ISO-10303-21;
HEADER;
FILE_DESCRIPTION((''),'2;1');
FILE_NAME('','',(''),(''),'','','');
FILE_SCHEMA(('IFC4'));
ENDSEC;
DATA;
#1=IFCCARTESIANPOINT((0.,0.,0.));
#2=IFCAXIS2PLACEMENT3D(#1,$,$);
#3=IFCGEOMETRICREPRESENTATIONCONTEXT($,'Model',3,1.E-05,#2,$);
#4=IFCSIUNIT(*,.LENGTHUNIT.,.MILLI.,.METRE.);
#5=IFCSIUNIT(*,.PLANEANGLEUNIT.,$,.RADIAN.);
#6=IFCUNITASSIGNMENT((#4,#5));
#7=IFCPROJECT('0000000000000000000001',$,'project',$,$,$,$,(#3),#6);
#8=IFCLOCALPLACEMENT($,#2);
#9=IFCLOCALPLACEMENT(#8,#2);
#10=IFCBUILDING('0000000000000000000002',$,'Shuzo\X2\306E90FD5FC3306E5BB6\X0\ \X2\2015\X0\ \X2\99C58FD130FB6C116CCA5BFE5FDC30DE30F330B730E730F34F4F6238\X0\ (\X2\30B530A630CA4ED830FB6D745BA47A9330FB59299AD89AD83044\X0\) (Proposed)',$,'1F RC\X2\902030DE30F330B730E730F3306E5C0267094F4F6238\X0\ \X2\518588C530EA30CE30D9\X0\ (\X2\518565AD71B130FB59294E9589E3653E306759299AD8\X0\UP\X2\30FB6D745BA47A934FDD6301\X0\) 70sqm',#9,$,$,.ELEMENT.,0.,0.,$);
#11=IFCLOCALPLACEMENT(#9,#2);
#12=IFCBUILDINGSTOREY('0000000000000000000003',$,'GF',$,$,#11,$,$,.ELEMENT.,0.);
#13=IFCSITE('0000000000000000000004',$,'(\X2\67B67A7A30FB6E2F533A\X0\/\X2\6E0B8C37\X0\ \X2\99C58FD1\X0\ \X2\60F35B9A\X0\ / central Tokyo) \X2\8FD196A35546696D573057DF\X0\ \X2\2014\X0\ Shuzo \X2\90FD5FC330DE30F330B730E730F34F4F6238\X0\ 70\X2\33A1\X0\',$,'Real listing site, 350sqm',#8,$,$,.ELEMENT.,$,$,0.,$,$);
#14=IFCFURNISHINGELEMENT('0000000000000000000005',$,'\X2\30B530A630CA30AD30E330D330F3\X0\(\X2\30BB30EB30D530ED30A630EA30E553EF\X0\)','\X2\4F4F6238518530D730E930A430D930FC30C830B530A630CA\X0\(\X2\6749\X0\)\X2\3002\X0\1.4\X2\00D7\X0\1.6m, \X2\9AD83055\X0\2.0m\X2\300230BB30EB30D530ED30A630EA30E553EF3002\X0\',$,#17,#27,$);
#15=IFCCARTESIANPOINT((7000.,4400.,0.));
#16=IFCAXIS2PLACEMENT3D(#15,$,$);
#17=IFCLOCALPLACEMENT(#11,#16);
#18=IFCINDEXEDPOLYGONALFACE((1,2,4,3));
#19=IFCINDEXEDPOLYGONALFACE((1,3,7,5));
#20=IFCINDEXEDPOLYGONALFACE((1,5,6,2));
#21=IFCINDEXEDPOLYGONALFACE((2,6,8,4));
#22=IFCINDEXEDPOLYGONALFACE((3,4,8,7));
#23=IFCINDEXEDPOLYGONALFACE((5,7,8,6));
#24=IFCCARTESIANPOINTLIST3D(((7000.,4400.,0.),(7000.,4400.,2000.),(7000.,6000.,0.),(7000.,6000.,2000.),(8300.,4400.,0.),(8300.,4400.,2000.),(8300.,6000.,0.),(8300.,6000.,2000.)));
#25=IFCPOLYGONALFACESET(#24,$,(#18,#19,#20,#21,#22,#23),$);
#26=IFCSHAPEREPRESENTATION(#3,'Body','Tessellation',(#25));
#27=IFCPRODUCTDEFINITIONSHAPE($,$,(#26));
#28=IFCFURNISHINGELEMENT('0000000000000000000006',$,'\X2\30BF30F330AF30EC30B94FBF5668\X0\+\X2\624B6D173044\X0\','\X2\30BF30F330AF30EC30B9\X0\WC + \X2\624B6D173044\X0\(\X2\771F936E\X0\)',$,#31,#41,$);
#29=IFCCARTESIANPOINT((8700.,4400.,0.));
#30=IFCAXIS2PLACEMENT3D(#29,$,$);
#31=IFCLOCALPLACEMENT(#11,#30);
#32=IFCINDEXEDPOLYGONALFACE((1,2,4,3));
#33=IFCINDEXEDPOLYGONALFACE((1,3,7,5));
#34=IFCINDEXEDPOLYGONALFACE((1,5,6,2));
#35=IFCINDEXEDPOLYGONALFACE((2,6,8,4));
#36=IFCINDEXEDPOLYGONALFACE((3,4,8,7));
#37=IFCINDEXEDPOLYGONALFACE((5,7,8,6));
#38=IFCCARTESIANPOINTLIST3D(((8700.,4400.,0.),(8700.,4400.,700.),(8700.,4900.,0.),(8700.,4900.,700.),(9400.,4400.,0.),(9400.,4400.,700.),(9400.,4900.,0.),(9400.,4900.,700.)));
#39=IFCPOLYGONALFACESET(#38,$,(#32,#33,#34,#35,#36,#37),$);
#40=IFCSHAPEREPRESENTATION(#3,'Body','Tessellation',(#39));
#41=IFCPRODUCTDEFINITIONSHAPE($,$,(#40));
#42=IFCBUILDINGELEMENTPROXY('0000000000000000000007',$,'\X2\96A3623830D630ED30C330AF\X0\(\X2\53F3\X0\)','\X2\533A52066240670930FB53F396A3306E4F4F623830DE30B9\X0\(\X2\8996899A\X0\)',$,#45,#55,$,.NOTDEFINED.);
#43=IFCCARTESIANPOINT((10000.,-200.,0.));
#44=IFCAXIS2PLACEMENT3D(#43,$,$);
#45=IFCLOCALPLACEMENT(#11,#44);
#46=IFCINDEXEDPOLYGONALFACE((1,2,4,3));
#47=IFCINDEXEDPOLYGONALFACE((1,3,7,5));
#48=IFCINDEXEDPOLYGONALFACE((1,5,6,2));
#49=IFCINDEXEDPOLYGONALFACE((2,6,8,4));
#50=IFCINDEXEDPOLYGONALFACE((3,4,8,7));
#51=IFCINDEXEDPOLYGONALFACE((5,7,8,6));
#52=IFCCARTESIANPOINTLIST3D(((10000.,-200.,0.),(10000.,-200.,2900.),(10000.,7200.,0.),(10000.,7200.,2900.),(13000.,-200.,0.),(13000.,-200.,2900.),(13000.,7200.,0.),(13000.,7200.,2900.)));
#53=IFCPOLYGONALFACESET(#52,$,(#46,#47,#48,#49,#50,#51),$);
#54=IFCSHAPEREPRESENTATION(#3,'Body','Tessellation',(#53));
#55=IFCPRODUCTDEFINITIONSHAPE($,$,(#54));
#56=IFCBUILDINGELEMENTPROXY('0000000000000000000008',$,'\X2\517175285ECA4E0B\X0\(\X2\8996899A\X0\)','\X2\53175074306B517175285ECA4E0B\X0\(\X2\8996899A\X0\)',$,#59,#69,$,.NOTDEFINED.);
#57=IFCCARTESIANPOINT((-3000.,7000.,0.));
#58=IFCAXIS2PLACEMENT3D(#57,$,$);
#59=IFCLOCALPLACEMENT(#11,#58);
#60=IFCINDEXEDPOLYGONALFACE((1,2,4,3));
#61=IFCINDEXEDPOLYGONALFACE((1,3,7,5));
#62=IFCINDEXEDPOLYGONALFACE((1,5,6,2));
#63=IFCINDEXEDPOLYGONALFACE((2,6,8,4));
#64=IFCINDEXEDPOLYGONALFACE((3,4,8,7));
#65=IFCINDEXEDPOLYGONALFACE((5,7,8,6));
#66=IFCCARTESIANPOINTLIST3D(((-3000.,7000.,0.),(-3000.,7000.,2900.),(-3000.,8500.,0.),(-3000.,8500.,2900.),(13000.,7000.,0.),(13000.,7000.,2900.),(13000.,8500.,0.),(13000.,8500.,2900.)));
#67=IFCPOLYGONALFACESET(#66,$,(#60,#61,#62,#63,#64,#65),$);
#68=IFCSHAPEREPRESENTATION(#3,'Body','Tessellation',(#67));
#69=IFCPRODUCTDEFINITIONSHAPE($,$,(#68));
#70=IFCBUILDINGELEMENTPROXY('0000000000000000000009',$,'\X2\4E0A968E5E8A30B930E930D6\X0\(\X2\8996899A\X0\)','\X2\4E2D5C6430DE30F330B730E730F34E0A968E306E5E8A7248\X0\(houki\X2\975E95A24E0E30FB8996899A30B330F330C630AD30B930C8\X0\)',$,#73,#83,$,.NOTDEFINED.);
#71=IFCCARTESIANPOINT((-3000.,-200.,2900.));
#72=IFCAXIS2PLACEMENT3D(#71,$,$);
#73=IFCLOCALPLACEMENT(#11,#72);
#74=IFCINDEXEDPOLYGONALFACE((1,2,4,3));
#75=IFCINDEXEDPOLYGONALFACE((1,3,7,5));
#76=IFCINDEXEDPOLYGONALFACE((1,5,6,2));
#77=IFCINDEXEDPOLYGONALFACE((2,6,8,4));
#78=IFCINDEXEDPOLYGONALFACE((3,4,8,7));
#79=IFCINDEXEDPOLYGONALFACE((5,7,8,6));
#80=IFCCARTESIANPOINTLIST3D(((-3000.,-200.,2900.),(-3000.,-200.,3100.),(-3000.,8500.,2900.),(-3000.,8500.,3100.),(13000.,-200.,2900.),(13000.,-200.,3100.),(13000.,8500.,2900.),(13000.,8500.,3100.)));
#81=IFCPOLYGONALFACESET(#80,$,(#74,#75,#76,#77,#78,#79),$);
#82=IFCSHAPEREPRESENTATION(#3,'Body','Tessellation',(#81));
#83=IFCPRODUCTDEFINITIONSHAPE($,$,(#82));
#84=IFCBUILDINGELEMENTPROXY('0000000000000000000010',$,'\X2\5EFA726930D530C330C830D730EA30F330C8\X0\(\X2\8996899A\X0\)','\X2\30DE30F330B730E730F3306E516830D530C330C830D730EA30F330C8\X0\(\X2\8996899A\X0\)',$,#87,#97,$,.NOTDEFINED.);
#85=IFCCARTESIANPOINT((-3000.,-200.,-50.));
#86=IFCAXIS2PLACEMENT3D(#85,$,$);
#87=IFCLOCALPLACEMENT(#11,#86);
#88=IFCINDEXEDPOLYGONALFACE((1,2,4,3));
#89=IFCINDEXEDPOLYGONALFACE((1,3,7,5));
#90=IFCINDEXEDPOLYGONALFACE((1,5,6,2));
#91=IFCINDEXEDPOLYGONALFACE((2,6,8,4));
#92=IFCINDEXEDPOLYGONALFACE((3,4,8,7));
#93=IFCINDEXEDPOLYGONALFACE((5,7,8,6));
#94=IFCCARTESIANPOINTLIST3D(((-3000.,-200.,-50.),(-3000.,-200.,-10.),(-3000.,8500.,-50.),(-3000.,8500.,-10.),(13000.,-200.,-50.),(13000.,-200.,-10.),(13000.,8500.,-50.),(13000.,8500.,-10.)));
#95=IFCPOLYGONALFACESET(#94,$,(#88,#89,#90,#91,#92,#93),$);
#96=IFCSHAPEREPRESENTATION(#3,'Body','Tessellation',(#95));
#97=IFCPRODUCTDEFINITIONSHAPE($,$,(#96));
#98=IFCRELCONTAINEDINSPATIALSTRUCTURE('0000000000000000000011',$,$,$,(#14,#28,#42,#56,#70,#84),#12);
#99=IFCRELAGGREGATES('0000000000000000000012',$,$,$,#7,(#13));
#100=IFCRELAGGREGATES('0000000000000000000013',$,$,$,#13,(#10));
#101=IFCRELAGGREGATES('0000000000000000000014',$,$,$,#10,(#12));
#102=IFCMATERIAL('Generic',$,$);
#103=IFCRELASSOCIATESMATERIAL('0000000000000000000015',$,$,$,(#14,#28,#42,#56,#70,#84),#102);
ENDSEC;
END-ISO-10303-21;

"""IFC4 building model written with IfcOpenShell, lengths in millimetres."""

from ifc_helpers import new_model, si_unit, frame, frame_2d, origin, place, context, project, spatial, rectangle, extrude, material, element, save


model = new_model("IFC4")

# Units and contexts
model_context = context("Model", 3, precision=1e-05, world=origin())
ifc_project = project(units=[si_unit("LENGTHUNIT", "METRE", prefix="MILLI"), si_unit("PLANEANGLEUNIT", "RADIAN")], contexts=[model_context])

# Site, building, storey
site_placement = place(None, origin())
site = spatial("IfcSite", under=ifc_project, at=site_placement, Name="(架空・港区/渋谷 駅近 想定 / central Tokyo) 近隣商業地域 — Shuzo 都心マンション住戸 70㎡", ObjectType="Real listing site, 350sqm", CompositionType="ELEMENT", RefElevation=0.0)
building_placement = place(site_placement, origin())
building = spatial("IfcBuilding", under=site, at=building_placement, Name="Shuzoの都心の家 ― 駅近・民泊対応マンション住戸 (サウナ付・浴室窓・天高高い) (Proposed)", ObjectType="1F RC造マンションの専有住戸 内装リノベ (内断熱・天井解放で天高UP・浴室窓保持) 70sqm", CompositionType="ELEMENT", ElevationOfRefHeight=0.0, ElevationOfTerrain=0.0)
storey_placement = place(building_placement, origin())
storey = spatial("IfcBuildingStorey", under=building, at=storey_placement, Name="GF", CompositionType="ELEMENT", Elevation=0.0)

# Shared definitions
ifc_material = material(Name="Generic")

# Furnishing elements
furnishing_1_placement = place(storey_placement, frame((7000.0, 4400.0, 0.0)))
element("IfcFurnishingElement", 1, at=furnishing_1_placement, inside=storey, material=ifc_material, Name="サウナキャビン(セルフロウリュ可)", Description="住戸内プライベートサウナ(杉)。1.4×1.6m, 高さ2.0m。セルフロウリュ可。", context=model_context, shape_type="SweptSolid", body=[
    extrude(rectangle(XDim=1300.0, YDim=1600.0, at=frame_2d((650.0, 800.0))), frame((7000.0, 4400.0, 0.0)), (0.0, 0.0, 1.0), 2000.0),
])
furnishing_2_placement = place(storey_placement, frame((8700.0, 4400.0, 0.0)))
element("IfcFurnishingElement", 2, at=furnishing_2_placement, inside=storey, material=ifc_material, Name="タンクレス便器+手洗い", Description="タンクレスWC + 手洗い(真鍮)", context=model_context, shape_type="SweptSolid", body=[
    extrude(rectangle(XDim=700.0, YDim=500.0, at=frame_2d((350.0, 250.0))), frame((8700.0, 4400.0, 0.0)), (0.0, 0.0, 1.0), 700.0),
])

# Building element proxies
proxy_1_placement = place(storey_placement, frame((10000.0, -200.0, 0.0)))
element("IfcBuildingElementProxy", 3, at=proxy_1_placement, inside=storey, material=ifc_material, Name="隣戸ブロック(右)", Description="区分所有・右隣の住戸マス(視覚)", PredefinedType="NOTDEFINED", context=model_context, shape_type="SweptSolid", body=[
    extrude(rectangle(XDim=3000.0, YDim=7400.0, at=frame_2d((1500.0, 3700.0))), frame((10000.0, -200.0, 0.0)), (0.0, 0.0, 1.0), 2900.0),
])
proxy_2_placement = place(storey_placement, frame((-3000.0, 7000.0, 0.0)))
element("IfcBuildingElementProxy", 4, at=proxy_2_placement, inside=storey, material=ifc_material, Name="共用廊下(視覚)", Description="北側に共用廊下(視覚)", PredefinedType="NOTDEFINED", context=model_context, shape_type="SweptSolid", body=[
    extrude(rectangle(XDim=16000.0, YDim=1500.0, at=frame_2d((8000.0, 750.0))), frame((-3000.0, 7000.0, 0.0)), (0.0, 0.0, 1.0), 2900.0),
])
proxy_3_placement = place(storey_placement, frame((-3000.0, -200.0, 2900.0)))
element("IfcBuildingElementProxy", 5, at=proxy_3_placement, inside=storey, material=ifc_material, Name="上階床スラブ(視覚)", Description="中層マンション上階の床版(houki非関与・視覚コンテキスト)", PredefinedType="NOTDEFINED", context=model_context, shape_type="SweptSolid", body=[
    extrude(rectangle(XDim=16000.0, YDim=8700.0, at=frame_2d((8000.0, 4350.0))), frame((-3000.0, -200.0, 2900.0)), (0.0, 0.0, 1.0), 200.0),
])
proxy_4_placement = place(storey_placement, frame((-3000.0, -200.0, -50.0)))
element("IfcBuildingElementProxy", 6, at=proxy_4_placement, inside=storey, material=ifc_material, Name="建物フットプリント(視覚)", Description="マンションの全フットプリント(視覚)", PredefinedType="NOTDEFINED", context=model_context, shape_type="SweptSolid", body=[
    extrude(rectangle(XDim=16000.0, YDim=8700.0, at=frame_2d((8000.0, 4350.0))), frame((-3000.0, -200.0, -50.0)), (0.0, 0.0, 1.0), 40.0),
])

save(model, "model.ifc")
